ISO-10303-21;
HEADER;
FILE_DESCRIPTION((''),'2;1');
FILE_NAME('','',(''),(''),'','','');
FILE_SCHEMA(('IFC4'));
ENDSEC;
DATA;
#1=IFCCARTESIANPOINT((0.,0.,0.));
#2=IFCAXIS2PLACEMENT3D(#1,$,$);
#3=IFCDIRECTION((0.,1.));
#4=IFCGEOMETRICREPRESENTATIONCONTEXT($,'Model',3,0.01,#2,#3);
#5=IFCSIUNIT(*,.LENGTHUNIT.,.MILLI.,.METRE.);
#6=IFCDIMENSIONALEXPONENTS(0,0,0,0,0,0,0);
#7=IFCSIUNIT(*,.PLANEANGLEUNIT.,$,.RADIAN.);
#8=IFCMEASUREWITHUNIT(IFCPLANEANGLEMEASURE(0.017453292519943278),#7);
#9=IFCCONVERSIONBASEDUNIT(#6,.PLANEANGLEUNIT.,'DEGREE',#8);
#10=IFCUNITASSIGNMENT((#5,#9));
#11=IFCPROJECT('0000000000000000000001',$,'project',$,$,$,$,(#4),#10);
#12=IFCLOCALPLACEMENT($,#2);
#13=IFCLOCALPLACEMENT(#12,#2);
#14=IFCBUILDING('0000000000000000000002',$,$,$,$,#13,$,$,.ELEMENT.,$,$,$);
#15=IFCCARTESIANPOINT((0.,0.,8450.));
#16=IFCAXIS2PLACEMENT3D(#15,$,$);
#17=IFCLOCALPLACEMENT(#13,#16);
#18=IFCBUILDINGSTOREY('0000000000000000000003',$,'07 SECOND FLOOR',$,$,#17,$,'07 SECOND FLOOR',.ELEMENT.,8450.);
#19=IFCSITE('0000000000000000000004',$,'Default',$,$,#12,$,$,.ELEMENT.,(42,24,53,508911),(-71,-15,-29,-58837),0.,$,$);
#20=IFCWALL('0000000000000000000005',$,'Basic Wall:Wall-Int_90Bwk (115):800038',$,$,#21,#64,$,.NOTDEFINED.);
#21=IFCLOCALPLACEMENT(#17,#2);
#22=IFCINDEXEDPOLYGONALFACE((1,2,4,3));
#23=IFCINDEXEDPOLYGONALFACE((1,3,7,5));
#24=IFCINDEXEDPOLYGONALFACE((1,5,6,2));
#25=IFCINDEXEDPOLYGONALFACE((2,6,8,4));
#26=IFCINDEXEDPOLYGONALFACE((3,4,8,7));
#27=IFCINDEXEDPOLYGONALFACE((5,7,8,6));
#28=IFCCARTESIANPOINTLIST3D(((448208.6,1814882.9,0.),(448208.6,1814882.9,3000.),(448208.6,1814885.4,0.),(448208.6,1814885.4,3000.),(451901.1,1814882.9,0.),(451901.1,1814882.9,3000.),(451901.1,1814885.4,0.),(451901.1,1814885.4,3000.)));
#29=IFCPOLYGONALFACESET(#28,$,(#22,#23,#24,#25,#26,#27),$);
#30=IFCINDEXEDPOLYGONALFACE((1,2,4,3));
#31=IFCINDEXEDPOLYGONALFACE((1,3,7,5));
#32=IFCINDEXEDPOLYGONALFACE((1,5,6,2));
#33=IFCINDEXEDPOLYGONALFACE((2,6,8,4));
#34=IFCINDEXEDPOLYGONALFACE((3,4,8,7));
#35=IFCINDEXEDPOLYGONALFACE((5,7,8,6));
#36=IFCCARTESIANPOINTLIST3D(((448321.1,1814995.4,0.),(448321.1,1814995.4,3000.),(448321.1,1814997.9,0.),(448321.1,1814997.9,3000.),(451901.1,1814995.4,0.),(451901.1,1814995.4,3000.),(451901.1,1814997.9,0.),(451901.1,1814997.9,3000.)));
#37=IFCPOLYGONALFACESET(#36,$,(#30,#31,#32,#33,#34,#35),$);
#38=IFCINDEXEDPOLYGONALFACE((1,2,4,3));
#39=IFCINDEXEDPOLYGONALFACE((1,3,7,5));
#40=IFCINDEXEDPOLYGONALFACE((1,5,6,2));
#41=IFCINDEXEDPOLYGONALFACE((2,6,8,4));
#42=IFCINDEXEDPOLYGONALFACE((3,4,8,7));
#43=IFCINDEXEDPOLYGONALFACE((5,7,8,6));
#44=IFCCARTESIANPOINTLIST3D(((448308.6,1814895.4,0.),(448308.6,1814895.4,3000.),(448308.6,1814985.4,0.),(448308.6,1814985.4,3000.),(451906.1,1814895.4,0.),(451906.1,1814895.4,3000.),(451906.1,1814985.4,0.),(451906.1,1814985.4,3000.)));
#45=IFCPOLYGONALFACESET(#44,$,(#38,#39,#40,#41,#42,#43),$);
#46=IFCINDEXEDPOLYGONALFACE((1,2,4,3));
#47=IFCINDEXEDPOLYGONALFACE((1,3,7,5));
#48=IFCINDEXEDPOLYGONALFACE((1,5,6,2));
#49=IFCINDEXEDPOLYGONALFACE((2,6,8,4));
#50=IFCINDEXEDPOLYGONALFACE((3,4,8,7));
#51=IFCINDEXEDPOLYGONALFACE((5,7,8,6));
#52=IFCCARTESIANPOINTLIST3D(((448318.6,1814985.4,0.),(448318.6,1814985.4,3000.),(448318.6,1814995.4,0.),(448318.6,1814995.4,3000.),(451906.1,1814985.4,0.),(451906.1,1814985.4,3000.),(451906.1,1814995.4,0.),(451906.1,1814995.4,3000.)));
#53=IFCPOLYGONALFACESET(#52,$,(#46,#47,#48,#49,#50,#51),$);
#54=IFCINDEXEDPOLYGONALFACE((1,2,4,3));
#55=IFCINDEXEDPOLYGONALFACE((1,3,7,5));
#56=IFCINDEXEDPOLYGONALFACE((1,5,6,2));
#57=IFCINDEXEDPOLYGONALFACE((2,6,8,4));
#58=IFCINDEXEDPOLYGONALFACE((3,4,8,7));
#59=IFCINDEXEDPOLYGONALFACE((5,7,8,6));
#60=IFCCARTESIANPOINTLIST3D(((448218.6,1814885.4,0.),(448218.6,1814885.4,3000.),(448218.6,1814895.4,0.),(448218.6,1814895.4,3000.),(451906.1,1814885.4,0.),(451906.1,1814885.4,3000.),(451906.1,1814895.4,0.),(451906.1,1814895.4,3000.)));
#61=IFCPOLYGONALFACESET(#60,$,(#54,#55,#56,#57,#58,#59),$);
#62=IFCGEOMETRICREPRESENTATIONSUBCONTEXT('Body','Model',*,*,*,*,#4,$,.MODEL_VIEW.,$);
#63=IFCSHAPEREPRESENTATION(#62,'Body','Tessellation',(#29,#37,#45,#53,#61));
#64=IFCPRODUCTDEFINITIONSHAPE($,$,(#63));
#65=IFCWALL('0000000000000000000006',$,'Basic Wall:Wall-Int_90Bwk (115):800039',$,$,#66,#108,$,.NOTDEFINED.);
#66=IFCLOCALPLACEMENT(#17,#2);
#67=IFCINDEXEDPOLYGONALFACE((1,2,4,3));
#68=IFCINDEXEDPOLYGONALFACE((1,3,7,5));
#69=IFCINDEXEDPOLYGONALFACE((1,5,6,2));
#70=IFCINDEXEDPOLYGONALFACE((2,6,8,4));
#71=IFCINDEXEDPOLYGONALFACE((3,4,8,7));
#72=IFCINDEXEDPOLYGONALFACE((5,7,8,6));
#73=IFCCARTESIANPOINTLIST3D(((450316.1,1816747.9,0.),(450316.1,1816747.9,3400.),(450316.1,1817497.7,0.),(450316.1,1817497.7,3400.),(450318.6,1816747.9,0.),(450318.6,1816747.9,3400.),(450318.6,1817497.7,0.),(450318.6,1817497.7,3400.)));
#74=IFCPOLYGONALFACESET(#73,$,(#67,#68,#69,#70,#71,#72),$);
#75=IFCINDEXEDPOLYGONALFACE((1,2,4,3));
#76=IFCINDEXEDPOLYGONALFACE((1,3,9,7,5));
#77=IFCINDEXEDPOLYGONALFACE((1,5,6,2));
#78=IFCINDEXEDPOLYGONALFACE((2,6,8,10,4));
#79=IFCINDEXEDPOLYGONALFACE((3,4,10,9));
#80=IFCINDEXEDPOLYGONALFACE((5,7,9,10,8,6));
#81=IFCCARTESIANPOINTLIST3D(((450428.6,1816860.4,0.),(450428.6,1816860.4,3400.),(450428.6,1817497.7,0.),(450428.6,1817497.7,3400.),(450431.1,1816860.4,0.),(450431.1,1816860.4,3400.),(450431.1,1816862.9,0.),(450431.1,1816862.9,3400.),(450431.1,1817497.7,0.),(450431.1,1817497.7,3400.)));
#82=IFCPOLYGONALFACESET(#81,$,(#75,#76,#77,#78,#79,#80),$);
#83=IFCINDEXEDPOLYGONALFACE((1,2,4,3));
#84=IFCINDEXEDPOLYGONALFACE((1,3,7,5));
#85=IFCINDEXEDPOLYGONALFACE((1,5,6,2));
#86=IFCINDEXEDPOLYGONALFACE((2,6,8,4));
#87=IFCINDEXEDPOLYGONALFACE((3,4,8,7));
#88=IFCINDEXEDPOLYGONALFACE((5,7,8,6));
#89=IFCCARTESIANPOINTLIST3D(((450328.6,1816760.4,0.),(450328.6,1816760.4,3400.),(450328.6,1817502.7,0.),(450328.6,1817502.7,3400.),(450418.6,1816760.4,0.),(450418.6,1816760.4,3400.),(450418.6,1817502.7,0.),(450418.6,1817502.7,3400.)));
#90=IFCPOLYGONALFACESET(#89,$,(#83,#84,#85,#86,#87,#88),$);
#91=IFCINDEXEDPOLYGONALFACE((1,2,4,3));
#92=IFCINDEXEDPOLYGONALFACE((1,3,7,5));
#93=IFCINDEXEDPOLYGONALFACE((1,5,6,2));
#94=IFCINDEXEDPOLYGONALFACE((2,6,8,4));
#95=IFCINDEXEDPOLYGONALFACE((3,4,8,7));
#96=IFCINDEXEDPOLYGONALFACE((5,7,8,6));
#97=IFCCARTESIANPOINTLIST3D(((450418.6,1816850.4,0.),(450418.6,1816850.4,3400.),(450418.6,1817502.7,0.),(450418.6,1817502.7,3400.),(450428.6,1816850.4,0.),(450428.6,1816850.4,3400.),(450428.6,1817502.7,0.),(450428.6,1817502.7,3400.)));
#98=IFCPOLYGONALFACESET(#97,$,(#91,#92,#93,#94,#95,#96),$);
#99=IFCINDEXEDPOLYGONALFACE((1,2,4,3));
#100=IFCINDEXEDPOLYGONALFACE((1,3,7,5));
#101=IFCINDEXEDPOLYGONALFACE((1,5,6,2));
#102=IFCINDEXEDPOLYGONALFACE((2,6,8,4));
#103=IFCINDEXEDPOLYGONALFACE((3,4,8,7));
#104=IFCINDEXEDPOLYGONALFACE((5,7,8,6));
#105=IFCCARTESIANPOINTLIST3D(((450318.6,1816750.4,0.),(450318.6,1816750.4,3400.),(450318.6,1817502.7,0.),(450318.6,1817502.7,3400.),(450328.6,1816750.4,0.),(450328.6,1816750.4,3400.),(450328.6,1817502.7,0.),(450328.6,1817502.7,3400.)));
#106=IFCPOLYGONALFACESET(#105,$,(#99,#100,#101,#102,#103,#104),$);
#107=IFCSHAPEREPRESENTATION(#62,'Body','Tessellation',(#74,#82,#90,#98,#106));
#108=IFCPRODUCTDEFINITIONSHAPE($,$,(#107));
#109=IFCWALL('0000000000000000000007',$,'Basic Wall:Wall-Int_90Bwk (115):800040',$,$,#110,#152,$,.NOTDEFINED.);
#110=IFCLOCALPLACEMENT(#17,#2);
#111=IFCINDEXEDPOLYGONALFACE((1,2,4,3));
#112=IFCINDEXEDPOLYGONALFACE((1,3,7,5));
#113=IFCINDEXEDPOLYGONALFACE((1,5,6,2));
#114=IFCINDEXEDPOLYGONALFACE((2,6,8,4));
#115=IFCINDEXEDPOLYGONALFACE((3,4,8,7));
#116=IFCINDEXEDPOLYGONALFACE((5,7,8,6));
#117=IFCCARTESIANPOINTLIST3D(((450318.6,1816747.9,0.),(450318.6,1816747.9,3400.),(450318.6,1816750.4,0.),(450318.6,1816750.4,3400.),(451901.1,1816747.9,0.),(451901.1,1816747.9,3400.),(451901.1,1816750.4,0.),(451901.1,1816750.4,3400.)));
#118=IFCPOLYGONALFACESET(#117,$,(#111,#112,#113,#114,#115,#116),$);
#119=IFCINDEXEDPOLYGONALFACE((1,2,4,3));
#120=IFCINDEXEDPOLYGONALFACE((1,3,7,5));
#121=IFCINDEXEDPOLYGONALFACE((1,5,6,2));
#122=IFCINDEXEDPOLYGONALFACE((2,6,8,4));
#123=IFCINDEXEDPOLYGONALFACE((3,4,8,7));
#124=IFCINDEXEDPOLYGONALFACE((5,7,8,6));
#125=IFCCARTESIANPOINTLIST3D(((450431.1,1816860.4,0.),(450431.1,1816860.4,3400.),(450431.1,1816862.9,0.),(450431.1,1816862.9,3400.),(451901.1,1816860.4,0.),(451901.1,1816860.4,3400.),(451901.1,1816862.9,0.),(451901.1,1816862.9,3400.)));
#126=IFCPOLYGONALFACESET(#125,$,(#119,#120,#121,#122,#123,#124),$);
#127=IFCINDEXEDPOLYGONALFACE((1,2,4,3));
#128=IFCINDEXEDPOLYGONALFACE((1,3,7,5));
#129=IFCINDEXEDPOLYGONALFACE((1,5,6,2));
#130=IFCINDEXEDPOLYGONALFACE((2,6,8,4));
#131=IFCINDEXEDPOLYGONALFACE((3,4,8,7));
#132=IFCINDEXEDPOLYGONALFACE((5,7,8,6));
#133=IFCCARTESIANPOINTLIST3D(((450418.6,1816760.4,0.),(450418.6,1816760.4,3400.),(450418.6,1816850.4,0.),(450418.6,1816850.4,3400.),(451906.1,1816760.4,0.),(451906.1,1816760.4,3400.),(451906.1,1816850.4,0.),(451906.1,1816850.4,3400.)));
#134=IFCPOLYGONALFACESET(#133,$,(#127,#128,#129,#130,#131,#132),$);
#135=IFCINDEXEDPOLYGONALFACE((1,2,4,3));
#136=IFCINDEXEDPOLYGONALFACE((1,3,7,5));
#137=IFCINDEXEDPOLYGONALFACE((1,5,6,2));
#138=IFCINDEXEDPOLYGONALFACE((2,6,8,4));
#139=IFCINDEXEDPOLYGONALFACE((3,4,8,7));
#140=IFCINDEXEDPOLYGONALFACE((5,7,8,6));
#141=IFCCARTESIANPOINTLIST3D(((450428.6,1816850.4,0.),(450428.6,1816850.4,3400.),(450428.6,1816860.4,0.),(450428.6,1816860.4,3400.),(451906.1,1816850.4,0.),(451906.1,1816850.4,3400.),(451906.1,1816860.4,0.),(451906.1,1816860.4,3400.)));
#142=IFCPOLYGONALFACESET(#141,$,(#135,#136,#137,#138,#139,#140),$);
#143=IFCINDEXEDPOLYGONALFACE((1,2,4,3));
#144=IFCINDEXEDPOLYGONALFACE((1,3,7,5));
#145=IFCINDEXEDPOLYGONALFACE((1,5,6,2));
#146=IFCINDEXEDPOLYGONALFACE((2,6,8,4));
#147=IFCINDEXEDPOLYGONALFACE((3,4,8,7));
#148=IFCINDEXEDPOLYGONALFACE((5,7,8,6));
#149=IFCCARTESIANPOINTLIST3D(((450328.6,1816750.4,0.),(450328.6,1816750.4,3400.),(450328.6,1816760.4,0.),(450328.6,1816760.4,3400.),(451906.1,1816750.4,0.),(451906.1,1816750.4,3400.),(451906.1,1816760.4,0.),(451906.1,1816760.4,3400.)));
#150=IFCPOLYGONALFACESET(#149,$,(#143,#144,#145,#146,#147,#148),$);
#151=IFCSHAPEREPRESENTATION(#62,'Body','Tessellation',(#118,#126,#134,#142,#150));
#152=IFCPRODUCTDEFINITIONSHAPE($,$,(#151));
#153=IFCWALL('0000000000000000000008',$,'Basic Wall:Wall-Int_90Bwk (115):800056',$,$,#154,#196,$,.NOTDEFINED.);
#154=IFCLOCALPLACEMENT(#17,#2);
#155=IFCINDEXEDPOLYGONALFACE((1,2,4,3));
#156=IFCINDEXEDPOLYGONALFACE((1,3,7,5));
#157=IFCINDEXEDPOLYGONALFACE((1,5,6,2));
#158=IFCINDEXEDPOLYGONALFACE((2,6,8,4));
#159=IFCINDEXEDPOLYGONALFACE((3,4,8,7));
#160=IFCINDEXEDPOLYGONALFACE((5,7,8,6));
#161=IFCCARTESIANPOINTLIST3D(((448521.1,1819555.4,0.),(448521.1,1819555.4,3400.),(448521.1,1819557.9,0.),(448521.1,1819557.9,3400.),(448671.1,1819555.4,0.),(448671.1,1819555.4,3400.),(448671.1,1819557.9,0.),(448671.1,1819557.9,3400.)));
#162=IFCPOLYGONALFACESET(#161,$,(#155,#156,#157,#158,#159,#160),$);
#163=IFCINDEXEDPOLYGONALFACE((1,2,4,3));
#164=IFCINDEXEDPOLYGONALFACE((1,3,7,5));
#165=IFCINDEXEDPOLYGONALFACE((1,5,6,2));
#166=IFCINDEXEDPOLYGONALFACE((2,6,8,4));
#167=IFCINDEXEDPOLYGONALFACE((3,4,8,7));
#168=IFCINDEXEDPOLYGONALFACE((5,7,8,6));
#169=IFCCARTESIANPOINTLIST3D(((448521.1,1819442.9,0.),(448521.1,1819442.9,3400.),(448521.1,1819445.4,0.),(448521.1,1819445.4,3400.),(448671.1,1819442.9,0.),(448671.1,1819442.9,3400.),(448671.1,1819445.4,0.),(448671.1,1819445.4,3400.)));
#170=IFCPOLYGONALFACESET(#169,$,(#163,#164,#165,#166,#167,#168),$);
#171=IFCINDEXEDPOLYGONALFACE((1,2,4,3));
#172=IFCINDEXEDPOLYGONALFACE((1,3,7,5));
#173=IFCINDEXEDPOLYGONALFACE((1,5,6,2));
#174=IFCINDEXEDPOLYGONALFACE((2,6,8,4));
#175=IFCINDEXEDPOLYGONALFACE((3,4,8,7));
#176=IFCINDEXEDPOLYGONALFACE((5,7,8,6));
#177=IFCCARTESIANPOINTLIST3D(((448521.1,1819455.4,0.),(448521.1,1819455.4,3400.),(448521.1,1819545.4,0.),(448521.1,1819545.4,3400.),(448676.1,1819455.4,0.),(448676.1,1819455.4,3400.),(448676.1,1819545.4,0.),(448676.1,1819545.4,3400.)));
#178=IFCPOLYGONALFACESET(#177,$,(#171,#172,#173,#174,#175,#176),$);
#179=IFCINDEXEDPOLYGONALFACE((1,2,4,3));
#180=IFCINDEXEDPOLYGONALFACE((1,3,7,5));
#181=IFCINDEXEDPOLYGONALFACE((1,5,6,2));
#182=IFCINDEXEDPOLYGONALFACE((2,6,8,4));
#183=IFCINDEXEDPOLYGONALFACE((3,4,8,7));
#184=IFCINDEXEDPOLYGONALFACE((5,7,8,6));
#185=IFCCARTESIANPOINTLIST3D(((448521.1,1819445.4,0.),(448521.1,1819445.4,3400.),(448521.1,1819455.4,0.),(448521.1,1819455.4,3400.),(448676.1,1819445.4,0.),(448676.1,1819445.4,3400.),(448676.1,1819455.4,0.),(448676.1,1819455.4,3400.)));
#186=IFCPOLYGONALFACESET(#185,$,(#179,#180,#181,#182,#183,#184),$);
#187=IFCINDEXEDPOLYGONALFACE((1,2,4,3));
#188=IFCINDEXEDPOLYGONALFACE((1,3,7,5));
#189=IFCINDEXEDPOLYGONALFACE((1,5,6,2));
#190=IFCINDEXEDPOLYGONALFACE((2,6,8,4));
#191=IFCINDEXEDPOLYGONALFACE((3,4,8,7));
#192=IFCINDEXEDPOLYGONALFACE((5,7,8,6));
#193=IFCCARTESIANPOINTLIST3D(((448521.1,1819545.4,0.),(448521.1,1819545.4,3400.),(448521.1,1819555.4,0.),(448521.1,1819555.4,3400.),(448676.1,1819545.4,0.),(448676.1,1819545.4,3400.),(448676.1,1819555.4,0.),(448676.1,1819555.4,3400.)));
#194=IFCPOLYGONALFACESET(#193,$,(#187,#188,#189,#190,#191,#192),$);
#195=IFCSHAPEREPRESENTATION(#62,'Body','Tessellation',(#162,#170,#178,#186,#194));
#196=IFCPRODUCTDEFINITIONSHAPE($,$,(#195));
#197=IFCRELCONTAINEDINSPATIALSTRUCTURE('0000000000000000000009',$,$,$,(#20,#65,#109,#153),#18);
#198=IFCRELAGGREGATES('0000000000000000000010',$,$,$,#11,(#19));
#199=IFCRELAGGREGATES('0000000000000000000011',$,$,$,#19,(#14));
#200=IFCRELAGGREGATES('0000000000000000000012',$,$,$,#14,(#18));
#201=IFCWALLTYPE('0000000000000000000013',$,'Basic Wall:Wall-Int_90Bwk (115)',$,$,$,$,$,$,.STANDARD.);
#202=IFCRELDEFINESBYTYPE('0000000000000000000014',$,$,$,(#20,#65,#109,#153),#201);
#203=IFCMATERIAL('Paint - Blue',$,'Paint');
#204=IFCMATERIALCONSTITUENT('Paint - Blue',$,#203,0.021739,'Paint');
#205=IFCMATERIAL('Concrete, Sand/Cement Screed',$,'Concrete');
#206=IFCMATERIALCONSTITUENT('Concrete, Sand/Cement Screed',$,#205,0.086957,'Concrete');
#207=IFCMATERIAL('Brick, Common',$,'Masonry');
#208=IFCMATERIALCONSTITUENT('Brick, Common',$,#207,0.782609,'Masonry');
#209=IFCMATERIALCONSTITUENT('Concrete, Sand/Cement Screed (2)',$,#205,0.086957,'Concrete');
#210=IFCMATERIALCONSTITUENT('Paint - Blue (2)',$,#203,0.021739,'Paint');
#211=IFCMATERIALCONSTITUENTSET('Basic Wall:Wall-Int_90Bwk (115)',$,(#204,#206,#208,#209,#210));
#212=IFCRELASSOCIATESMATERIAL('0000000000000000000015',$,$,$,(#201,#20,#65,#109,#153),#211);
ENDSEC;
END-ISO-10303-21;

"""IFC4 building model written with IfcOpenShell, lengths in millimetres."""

from ifc_helpers import new_model, entity, si_unit, converted_unit, direction, frame, origin, place, context, subcontext, project, spatial, indexed_curve, outline, extrude, material, constituent, constituent_set, type_object, element, save


model = new_model("IFC4")

# Units and contexts
model_context = context("Model", 3, precision=0.01, world=origin(), true_north=direction((0.0, 1.0)))
body_context = subcontext(model_context, "Body", "Model", "MODEL_VIEW")
ifc_project = project(units=[si_unit("LENGTHUNIT", "METRE", prefix="MILLI"), converted_unit("PLANEANGLEUNIT", "DEGREE", entity("IfcPlaneAngleMeasure", 0.017453292519943278), si_unit("PLANEANGLEUNIT", "RADIAN"), dimensions=[0, 0, 0, 0, 0, 0, 0])], contexts=[model_context])

# Site, building, storey
site_placement = place(None, origin())
site = spatial("IfcSite", under=ifc_project, at=site_placement, Name="Default", CompositionType="ELEMENT", RefLatitude=(42, 24, 53, 508911), RefLongitude=(-71, -15, -29, -58837), RefElevation=0.0)
building_placement = place(site_placement, origin())
building = spatial("IfcBuilding", under=site, at=building_placement, CompositionType="ELEMENT")
storey_placement = place(building_placement, frame((0.0, 0.0, 8450.0)))
storey = spatial("IfcBuildingStorey", under=building, at=storey_placement, Name="07 SECOND FLOOR", LongName="07 SECOND FLOOR", CompositionType="ELEMENT", Elevation=8450.0)

# Shared definitions
ifc_material_1 = material(Name="Paint - Blue", Category="Paint")
ifc_constituent_1 = constituent(ifc_material_1, Name="Paint - Blue", Category="Paint", fraction=0.021739)
ifc_material_2 = material(Name="Concrete, Sand/Cement Screed", Category="Concrete")
ifc_constituent_2 = constituent(ifc_material_2, Name="Concrete, Sand/Cement Screed", Category="Concrete", fraction=0.086957)
ifc_material_3 = material(Name="Brick, Common", Category="Masonry")
ifc_constituent_3 = constituent(ifc_material_3, Name="Brick, Common", Category="Masonry", fraction=0.782609)
ifc_constituent_4 = constituent(ifc_material_2, Name="Concrete, Sand/Cement Screed (2)", Category="Concrete", fraction=0.086957)
ifc_constituent_5 = constituent(ifc_material_1, Name="Paint - Blue (2)", Category="Paint", fraction=0.021739)
ifc_constituent_set_1 = constituent_set(constituents=[ifc_constituent_1, ifc_constituent_2, ifc_constituent_3, ifc_constituent_4, ifc_constituent_5], Name="Basic Wall:Wall-Int_90Bwk (115)")
wall_type_1 = type_object("IfcWallType", Name="Basic Wall:Wall-Int_90Bwk (115)", PredefinedType="STANDARD", material=ifc_constituent_set_1)

# Walls
wall_1_placement = place(storey_placement, frame((448321.1, 1814940.4, 0.0)))
element("IfcWall", 1, at=wall_1_placement, inside=storey, type_object=wall_type_1, material=ifc_constituent_set_1, Name="Basic Wall:Wall-Int_90Bwk (115):800038", PredefinedType="NOTDEFINED", context=body_context, shape_type="SweptSolid", body=[
    extrude(outline(indexed_curve([(-1.2, -1846.3), (1.3, -1846.3), (1.3, 1846.3), (-1.2, 1846.3), (-1.2, -1846.3)], self_intersect=False)), frame((1733.8, -56.3, 0.0), z_axis=(0.0, 0.0, 1.0), x_axis=(0.0, 1.0, 0.0)), (0.0, 0.0, 1.0), 3000.0),
    extrude(outline(indexed_curve([(-1.2, -1790.0), (1.3, -1790.0), (1.3, 1790.0), (-1.2, 1790.0), (-1.2, -1790.0)], self_intersect=False)), frame((1790.0, 56.3, 0.0), z_axis=(0.0, 0.0, 1.0), x_axis=(0.0, -1.0, 0.0)), (0.0, 0.0, 1.0), 3000.0),
    extrude(outline(indexed_curve([(-1798.8, -45.0), (1798.8, -45.0), (1798.8, 45.0), (-1798.8, 45.0), (-1798.8, -45.0)], self_intersect=False)), frame((1786.3, 0.0, 0.0)), (0.0, 0.0, 1.0), 3000.0),
    extrude(outline(indexed_curve([(-1793.8, -5.0), (1793.8, -5.0), (1793.8, 5.0), (-1793.8, 5.0), (-1793.8, -5.0)], self_intersect=False)), frame((1791.3, 50.0, 0.0)), (0.0, 0.0, 1.0), 3000.0),
    extrude(outline(indexed_curve([(-1843.8, -5.0), (1843.8, -5.0), (1843.8, 5.0), (-1843.8, 5.0), (-1843.8, -5.0)], self_intersect=False)), frame((1741.3, -50.0, 0.0)), (0.0, 0.0, 1.0), 3000.0),
])
wall_2_placement = place(storey_placement, frame((450373.6, 1817497.7, 0.0), z_axis=(0.0, 0.0, 1.0), x_axis=(0.0, -1.0, 0.0)))
element("IfcWall", 2, at=wall_2_placement, inside=storey, type_object=wall_type_1, material=ifc_constituent_set_1, Name="Basic Wall:Wall-Int_90Bwk (115):800039", PredefinedType="NOTDEFINED", context=body_context, shape_type="SweptSolid", body=[
    extrude(outline(indexed_curve([(-1.3, -374.9), (1.2, -374.9), (1.2, 374.9), (-1.3, 374.9), (-1.3, -374.9)], self_intersect=False)), frame((374.9, -56.2, 0.0), z_axis=(0.0, 0.0, 1.0), x_axis=(0.0, 1.0, 0.0)), (0.0, 0.0, 1.0), 3400.0),
    extrude(outline(indexed_curve([(-252.9, -1.0), (381.9, -1.0), (381.9, 1.5), (-255.4, 1.5), (-255.4, -1.0), (-252.9, -1.0)], self_intersect=False)), frame((381.9, 56.5, 0.0), z_axis=(0.0, 0.0, 1.0), x_axis=(-1.0, 0.0, 0.0)), (0.0, 0.0, 1.0), 3400.0),
    extrude(outline(indexed_curve([(-371.2, -45.0), (371.2, -45.0), (371.2, 45.0), (-371.2, 45.0), (-371.2, -45.0)], self_intersect=False)), frame((366.2, 0.0, 0.0)), (0.0, 0.0, 1.0), 3400.0),
    extrude(outline(indexed_curve([(-326.2, -5.0), (326.2, -5.0), (326.2, 5.0), (-326.2, 5.0), (-326.2, -5.0)], self_intersect=False)), frame((321.2, 50.0, 0.0)), (0.0, 0.0, 1.0), 3400.0),
    extrude(outline(indexed_curve([(-376.2, -5.0), (376.2, -5.0), (376.2, 5.0), (-376.2, 5.0), (-376.2, -5.0)], self_intersect=False)), frame((371.2, -50.0, 0.0)), (0.0, 0.0, 1.0), 3400.0),
])
wall_3_placement = place(storey_placement, frame((450431.1, 1816805.4, 0.0)))
element("IfcWall", 3, at=wall_3_placement, inside=storey, type_object=wall_type_1, material=ifc_constituent_set_1, Name="Basic Wall:Wall-Int_90Bwk (115):800040", PredefinedType="NOTDEFINED", context=body_context, shape_type="SweptSolid", body=[
    extrude(outline(indexed_curve([(-1.2, -791.3), (1.3, -791.3), (1.3, 791.3), (-1.2, 791.3), (-1.2, -791.3)], self_intersect=False)), frame((678.8, -56.3, 0.0), z_axis=(0.0, 0.0, 1.0), x_axis=(0.0, 1.0, 0.0)), (0.0, 0.0, 1.0), 3400.0),
    extrude(outline(indexed_curve([(-1.2, -735.0), (1.3, -735.0), (1.3, 735.0), (-1.2, 735.0), (-1.2, -735.0)], self_intersect=False)), frame((735.0, 56.3, 0.0), z_axis=(0.0, 0.0, 1.0), x_axis=(0.0, -1.0, 0.0)), (0.0, 0.0, 1.0), 3400.0),
    extrude(outline(indexed_curve([(-743.8, -45.0), (743.8, -45.0), (743.8, 45.0), (-743.8, 45.0), (-743.8, -45.0)], self_intersect=False)), frame((731.3, 0.0, 0.0)), (0.0, 0.0, 1.0), 3400.0),
    extrude(outline(indexed_curve([(-738.8, -5.0), (738.8, -5.0), (738.8, 5.0), (-738.8, 5.0), (-738.8, -5.0)], self_intersect=False)), frame((736.3, 50.0, 0.0)), (0.0, 0.0, 1.0), 3400.0),
    extrude(outline(indexed_curve([(-788.8, -5.0), (788.8, -5.0), (788.8, 5.0), (-788.8, 5.0), (-788.8, -5.0)], self_intersect=False)), frame((686.3, -50.0, 0.0)), (0.0, 0.0, 1.0), 3400.0),
])
wall_4_placement = place(storey_placement, frame((448671.1, 1819500.4, 0.0), z_axis=(0.0, 0.0, 1.0), x_axis=(-1.0, 0.0, 0.0)))
element("IfcWall", 4, at=wall_4_placement, inside=storey, type_object=wall_type_1, material=ifc_constituent_set_1, Name="Basic Wall:Wall-Int_90Bwk (115):800056", PredefinedType="NOTDEFINED", context=body_context, shape_type="SweptSolid", body=[
    extrude(outline(indexed_curve([(-1.2, -75.0), (1.3, -75.0), (1.3, 75.0), (-1.2, 75.0), (-1.2, -75.0)], self_intersect=False)), frame((75.0, -56.3, 0.0), z_axis=(0.0, 0.0, 1.0), x_axis=(0.0, 1.0, 0.0)), (0.0, 0.0, 1.0), 3400.0),
    extrude(outline(indexed_curve([(-1.2, -75.0), (1.3, -75.0), (1.3, 75.0), (-1.2, 75.0), (-1.2, -75.0)], self_intersect=False)), frame((75.0, 56.3, 0.0), z_axis=(0.0, 0.0, 1.0), x_axis=(0.0, -1.0, 0.0)), (0.0, 0.0, 1.0), 3400.0),
    extrude(outline(indexed_curve([(-77.5, -45.0), (77.5, -45.0), (77.5, 45.0), (-77.5, 45.0), (-77.5, -45.0)], self_intersect=False)), frame((72.5, 0.0, 0.0)), (0.0, 0.0, 1.0), 3400.0),
    extrude(outline(indexed_curve([(-77.5, -5.0), (77.5, -5.0), (77.5, 5.0), (-77.5, 5.0), (-77.5, -5.0)], self_intersect=False)), frame((72.5, 50.0, 0.0)), (0.0, 0.0, 1.0), 3400.0),
    extrude(outline(indexed_curve([(-77.5, -5.0), (77.5, -5.0), (77.5, 5.0), (-77.5, 5.0), (-77.5, -5.0)], self_intersect=False)), frame((72.5, -50.0, 0.0)), (0.0, 0.0, 1.0), 3400.0),
])

save(model, "model.ifc")
